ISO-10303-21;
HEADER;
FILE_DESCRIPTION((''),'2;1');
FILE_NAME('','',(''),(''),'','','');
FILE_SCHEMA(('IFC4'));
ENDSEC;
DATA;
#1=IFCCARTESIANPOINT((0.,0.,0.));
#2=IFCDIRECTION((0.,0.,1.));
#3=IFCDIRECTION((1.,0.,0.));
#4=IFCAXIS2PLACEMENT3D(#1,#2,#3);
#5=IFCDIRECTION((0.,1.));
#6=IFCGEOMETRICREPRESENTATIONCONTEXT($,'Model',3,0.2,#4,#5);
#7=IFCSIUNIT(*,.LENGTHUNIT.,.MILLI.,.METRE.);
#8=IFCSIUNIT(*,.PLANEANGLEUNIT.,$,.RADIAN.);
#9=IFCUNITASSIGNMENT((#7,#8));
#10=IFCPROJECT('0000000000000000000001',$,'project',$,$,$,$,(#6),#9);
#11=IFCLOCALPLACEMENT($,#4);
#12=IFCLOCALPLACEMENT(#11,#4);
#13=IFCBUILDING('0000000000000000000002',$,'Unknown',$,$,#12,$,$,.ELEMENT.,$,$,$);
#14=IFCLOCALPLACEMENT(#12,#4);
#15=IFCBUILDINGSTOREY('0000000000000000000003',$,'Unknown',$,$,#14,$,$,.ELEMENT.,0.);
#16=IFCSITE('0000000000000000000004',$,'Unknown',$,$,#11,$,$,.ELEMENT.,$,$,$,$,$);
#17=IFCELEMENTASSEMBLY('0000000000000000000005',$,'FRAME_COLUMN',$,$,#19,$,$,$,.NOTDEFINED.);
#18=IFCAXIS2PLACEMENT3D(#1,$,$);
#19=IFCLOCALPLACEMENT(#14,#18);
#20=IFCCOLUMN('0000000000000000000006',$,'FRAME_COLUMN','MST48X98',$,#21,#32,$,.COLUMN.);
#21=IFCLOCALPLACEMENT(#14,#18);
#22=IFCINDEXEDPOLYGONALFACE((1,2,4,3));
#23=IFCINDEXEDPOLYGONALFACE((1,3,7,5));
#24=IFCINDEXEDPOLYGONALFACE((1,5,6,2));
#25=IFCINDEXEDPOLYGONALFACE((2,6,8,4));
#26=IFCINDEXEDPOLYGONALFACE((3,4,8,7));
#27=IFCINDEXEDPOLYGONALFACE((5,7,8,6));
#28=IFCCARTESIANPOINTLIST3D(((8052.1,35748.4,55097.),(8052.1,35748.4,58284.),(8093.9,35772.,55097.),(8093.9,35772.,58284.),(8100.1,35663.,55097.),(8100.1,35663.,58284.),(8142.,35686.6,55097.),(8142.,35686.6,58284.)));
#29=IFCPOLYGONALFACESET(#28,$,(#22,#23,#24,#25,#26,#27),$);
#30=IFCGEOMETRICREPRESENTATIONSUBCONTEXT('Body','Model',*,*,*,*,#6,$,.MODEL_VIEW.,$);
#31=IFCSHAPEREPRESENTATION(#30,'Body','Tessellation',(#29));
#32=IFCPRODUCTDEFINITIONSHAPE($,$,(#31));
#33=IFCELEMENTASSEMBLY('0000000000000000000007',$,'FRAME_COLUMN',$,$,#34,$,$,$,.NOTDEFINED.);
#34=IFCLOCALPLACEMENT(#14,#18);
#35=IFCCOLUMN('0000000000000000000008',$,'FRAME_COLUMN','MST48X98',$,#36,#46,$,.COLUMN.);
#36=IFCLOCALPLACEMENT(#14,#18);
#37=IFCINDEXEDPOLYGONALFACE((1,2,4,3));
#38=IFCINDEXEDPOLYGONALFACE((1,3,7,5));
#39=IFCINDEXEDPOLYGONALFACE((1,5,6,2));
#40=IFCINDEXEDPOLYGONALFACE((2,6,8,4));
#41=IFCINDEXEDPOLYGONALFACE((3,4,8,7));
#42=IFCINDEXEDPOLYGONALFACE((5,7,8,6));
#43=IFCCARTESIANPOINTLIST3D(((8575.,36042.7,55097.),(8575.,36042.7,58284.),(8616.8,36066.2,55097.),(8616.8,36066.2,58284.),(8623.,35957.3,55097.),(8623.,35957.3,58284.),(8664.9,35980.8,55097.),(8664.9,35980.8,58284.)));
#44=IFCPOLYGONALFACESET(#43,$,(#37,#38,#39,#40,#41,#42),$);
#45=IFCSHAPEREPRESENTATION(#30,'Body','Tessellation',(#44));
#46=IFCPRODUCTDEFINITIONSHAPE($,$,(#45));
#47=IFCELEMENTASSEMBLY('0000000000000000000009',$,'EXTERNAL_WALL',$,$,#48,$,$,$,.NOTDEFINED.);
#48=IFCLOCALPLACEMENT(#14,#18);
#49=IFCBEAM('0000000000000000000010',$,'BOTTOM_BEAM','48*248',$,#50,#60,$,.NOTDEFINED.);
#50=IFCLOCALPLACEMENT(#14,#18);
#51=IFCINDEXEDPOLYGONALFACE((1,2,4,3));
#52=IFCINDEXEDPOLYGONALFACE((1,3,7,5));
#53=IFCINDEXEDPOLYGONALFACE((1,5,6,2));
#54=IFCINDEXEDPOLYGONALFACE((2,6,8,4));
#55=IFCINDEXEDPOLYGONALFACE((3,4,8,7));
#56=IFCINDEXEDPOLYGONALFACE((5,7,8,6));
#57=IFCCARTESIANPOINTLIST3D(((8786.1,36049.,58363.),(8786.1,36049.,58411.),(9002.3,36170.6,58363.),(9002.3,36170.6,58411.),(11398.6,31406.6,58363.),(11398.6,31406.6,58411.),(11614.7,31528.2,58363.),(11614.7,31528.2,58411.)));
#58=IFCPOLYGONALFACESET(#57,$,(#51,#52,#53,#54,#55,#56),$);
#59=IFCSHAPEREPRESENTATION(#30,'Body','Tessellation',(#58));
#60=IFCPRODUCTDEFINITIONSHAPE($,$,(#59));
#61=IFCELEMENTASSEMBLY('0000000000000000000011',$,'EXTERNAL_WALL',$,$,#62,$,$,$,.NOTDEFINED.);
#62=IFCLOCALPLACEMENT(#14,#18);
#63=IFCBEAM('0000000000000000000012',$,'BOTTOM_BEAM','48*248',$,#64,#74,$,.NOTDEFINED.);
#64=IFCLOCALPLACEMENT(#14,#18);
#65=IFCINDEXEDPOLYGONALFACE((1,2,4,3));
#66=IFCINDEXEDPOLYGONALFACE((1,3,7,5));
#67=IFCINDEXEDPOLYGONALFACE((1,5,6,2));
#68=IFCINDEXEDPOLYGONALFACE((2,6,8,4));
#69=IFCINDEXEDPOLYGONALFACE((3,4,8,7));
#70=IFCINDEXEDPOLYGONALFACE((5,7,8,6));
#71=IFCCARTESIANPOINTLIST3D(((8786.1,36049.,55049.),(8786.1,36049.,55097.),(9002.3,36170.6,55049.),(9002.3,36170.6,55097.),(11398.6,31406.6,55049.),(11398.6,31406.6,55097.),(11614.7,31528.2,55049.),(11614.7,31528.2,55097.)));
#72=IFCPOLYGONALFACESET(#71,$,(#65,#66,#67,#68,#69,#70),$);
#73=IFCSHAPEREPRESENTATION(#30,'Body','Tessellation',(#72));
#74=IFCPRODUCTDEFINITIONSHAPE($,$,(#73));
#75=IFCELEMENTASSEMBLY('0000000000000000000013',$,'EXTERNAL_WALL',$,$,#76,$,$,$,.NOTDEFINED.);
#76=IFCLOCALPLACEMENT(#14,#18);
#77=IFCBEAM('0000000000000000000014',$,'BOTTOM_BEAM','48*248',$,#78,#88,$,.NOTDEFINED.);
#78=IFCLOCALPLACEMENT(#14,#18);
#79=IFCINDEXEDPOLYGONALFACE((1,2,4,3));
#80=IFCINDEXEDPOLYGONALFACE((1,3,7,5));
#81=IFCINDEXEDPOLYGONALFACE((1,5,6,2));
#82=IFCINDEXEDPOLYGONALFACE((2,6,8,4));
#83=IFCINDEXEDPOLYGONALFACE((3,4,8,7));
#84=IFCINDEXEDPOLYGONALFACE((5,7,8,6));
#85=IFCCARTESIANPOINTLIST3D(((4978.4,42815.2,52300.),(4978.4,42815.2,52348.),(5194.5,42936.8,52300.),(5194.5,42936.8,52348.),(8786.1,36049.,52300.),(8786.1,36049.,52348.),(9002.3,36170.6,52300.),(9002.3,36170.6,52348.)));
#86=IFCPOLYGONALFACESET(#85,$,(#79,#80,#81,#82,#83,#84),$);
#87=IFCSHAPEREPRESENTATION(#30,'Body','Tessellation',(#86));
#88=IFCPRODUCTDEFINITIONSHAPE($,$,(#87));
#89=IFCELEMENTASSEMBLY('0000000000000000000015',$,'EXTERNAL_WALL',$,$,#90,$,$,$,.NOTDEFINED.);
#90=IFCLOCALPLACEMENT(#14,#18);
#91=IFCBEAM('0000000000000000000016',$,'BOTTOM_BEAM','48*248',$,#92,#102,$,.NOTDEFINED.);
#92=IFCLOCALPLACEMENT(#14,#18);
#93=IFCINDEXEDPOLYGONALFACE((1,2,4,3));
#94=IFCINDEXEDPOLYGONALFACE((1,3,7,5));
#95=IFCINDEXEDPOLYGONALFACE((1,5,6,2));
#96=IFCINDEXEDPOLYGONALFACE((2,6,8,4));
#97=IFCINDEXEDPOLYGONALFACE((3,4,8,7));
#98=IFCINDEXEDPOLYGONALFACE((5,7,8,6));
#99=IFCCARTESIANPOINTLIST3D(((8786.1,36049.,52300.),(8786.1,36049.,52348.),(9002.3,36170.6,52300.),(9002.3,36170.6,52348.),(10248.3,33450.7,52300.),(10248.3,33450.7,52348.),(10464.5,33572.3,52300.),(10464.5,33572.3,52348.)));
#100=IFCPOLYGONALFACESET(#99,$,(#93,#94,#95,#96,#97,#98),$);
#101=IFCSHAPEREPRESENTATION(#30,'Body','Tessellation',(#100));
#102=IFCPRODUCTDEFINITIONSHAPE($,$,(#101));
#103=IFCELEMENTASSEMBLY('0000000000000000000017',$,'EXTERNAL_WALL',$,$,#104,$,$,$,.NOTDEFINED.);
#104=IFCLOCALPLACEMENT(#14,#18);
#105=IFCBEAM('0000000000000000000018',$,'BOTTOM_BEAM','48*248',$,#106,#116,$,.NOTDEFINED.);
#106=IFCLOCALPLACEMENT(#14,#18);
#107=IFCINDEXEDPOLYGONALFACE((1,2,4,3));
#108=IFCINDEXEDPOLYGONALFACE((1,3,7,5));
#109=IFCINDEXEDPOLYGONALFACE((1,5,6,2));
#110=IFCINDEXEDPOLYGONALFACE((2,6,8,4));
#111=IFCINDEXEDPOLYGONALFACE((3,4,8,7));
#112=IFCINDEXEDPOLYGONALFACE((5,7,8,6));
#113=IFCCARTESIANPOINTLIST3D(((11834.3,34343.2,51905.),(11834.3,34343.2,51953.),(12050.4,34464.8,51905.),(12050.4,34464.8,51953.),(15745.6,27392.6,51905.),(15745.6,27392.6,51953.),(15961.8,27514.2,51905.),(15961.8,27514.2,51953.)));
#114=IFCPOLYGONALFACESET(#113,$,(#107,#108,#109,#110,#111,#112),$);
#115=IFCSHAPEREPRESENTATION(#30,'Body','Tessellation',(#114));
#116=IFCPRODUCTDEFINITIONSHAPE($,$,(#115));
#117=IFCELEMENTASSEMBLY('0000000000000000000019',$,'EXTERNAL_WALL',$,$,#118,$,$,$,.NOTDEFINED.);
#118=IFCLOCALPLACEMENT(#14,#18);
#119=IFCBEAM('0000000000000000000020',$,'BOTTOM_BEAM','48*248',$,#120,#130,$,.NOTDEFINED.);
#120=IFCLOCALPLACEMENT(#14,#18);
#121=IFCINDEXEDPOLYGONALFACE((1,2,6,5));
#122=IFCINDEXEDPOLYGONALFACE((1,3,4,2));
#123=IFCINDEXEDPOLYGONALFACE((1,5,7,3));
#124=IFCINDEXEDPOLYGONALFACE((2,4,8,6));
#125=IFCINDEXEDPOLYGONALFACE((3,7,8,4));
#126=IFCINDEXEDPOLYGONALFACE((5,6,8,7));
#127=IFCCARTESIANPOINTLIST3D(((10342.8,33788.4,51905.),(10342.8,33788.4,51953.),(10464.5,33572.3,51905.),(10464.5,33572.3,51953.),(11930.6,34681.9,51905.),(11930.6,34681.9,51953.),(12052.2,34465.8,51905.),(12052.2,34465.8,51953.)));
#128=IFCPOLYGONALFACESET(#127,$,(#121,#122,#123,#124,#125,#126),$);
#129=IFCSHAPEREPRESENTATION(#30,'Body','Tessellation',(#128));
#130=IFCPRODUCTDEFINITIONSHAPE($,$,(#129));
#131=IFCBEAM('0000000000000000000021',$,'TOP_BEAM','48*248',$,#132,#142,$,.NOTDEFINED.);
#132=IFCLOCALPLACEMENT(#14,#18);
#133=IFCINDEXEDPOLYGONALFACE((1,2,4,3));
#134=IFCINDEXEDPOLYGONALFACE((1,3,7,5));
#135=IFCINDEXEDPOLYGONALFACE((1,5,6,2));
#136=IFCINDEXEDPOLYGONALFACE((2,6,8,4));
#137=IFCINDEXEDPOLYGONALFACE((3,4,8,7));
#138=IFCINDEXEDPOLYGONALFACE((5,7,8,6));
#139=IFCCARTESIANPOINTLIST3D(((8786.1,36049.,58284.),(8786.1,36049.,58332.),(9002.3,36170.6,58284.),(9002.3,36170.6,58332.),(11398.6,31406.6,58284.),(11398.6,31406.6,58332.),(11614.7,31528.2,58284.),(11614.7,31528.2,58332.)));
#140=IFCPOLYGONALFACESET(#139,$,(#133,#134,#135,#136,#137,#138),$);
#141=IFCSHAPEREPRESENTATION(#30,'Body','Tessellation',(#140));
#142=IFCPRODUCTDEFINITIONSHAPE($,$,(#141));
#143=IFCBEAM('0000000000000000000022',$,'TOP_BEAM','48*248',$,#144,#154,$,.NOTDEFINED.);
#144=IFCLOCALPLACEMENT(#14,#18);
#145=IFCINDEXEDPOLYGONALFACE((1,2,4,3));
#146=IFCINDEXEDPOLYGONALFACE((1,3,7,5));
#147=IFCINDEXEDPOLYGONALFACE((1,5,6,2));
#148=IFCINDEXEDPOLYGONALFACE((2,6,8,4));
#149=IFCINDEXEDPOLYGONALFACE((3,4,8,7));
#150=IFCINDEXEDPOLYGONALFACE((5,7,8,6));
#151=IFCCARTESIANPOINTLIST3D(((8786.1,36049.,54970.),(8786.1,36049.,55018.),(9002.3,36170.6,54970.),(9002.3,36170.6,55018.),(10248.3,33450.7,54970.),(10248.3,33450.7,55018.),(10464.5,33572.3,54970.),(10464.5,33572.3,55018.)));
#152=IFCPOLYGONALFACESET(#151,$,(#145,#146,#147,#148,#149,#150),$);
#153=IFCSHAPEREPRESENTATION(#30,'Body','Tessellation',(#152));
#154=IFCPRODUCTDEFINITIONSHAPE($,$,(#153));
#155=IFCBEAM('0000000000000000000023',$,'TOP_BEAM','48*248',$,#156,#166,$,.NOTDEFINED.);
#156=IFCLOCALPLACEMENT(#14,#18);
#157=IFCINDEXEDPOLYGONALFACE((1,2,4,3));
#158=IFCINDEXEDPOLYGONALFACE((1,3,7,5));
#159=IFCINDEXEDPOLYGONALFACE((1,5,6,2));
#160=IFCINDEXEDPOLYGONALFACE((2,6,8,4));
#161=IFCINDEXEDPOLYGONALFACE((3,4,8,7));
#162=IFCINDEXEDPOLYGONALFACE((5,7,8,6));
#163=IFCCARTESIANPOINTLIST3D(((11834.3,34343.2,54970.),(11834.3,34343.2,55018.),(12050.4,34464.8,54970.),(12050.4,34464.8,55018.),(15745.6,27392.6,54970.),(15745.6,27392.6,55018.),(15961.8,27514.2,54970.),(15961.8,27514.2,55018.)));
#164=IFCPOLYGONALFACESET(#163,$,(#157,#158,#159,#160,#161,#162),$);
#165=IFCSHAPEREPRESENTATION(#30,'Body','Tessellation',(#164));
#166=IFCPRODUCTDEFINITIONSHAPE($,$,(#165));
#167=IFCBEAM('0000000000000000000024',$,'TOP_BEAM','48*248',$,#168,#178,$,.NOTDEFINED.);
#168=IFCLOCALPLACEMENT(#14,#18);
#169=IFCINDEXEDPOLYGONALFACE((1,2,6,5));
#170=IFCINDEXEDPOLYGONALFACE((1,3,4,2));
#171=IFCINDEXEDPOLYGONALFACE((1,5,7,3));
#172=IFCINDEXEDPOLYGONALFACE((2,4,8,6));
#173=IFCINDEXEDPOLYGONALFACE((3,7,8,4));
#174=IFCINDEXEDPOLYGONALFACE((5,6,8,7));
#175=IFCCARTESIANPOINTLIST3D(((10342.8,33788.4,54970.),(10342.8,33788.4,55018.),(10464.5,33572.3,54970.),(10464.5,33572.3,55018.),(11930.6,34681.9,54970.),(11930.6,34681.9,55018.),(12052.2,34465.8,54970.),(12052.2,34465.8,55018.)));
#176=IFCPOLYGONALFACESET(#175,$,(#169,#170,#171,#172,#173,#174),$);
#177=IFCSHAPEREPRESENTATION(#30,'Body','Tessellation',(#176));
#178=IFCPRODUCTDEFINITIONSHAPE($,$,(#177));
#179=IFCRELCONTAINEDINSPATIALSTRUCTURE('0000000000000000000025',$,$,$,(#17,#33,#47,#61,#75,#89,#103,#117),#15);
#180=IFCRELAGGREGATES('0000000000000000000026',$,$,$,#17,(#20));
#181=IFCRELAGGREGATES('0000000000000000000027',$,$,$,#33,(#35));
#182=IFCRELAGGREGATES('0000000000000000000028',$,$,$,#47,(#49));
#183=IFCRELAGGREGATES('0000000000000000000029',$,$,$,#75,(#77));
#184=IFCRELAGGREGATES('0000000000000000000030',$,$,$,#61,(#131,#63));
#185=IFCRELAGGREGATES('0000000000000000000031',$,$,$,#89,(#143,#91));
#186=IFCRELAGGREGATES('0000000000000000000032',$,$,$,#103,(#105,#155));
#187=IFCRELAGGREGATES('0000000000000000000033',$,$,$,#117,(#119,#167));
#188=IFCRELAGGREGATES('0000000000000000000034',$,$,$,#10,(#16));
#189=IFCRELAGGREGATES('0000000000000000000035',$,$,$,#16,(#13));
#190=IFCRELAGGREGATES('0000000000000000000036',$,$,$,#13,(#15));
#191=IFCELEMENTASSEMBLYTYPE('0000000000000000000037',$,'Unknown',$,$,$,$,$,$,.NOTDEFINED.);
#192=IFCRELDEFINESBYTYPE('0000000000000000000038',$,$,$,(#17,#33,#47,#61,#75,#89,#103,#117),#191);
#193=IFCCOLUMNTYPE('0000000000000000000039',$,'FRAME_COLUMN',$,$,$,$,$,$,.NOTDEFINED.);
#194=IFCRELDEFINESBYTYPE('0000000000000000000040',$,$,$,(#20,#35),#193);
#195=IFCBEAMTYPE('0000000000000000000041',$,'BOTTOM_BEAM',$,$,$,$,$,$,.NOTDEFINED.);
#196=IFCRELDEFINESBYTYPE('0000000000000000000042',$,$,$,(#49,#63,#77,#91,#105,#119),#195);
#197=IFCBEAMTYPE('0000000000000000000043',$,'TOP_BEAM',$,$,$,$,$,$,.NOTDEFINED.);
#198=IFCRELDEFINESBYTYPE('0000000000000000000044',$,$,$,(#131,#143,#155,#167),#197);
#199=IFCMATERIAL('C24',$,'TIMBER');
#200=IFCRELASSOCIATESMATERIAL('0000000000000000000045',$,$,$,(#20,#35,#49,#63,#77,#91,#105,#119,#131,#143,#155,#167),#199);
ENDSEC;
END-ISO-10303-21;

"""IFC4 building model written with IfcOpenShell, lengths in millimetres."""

from ifc_helpers import new_model, si_unit, direction, frame, origin_with_axes, origin_2d_with_axis, place, context, subcontext, project, spatial, polyline, rectangle, outline, extrude, material, material_profile, profile_set, profile_usage, type_object, element, aggregate, save


model = new_model("IFC4")

# Units and contexts
model_context = context("Model", 3, precision=0.2, world=origin_with_axes(), true_north=direction((0.0, 1.0)))
body_context = subcontext(model_context, "Body", "Model", "MODEL_VIEW")
ifc_project = project(units=[si_unit("LENGTHUNIT", "METRE", prefix="MILLI"), si_unit("PLANEANGLEUNIT", "RADIAN")], contexts=[model_context])

# Site, building, storey
site_placement = place(None, origin_with_axes())
site = spatial("IfcSite", under=ifc_project, at=site_placement, Name="Unknown", CompositionType="ELEMENT")
building_placement = place(site_placement, origin_with_axes())
building = spatial("IfcBuilding", under=site, at=building_placement, Name="Unknown", CompositionType="ELEMENT")
storey_placement = place(building_placement, origin_with_axes())
storey = spatial("IfcBuildingStorey", under=building, at=storey_placement, Name="Unknown", CompositionType="ELEMENT", Elevation=0.0)

# Element assemblies, columns
element_assembly_type = type_object("IfcElementAssemblyType", Name="Unknown", PredefinedType="NOTDEFINED")
ifc_material_1 = material(Name="C24", Category="TIMBER")
ifc_material_profile_1 = material_profile(ifc_material_1, outline(polyline([(-24.0, 49.0), (-24.0, -49.0), (24.0, -49.0), (24.0, 49.0), (-24.0, 49.0)])), Name="MST48X98")
ifc_profile_set_1 = profile_set([ifc_material_profile_1])
column_type = type_object("IfcColumnType", Name="FRAME_COLUMN")
ifc_profile_usage_1 = profile_usage(ifc_profile_set_1, cardinal=9)
assembly_1_placement = place(storey_placement, frame((8097.0, 35717.5, 55097.0), z_axis=(-0.871487, -0.490418, 0.0), x_axis=(0.0, 0.0, 1.0)))
assembly_1 = element("IfcElementAssembly", 1, at=assembly_1_placement, inside=storey, type_object=element_assembly_type, Name="FRAME_COLUMN", PredefinedType="NOTDEFINED")
column_1_placement = place(assembly_1_placement, origin_with_axes())
column_1 = element("IfcColumn", 2, at=column_1_placement, type_object=column_type, material=ifc_profile_usage_1, Name="FRAME_COLUMN", Description="MST48X98", PredefinedType="COLUMN", context=body_context, shape_type="SolidModel", body=[
    extrude(outline(polyline([(-24.0, 49.0), (-24.0, -49.0), (24.0, -49.0), (24.0, 49.0), (-24.0, 49.0)])), frame((0.0, 0.0, 0.0), z_axis=(-1.0, 0.0, 0.0), x_axis=(0.0, 0.0, 1.0)), (0.0, 0.0, -1.0), 3187.0),
])
aggregate(assembly_1, [column_1])
assembly_2_placement = place(storey_placement, frame((8619.9, 36011.8, 55097.0), z_axis=(-0.871487, -0.490418, 0.0), x_axis=(0.0, 0.0, 1.0)))
assembly_2 = element("IfcElementAssembly", 3, at=assembly_2_placement, inside=storey, type_object=element_assembly_type, Name="FRAME_COLUMN", PredefinedType="NOTDEFINED")
column_2_placement = place(assembly_2_placement, origin_with_axes())
column_2 = element("IfcColumn", 4, at=column_2_placement, type_object=column_type, material=ifc_profile_usage_1, Name="FRAME_COLUMN", Description="MST48X98", PredefinedType="COLUMN", context=body_context, shape_type="SolidModel", body=[
    extrude(outline(polyline([(-24.0, 49.0), (-24.0, -49.0), (24.0, -49.0), (24.0, 49.0), (-24.0, 49.0)])), frame((0.0, 0.0, 0.0), z_axis=(-1.0, 0.0, 0.0), x_axis=(0.0, 0.0, 1.0)), (0.0, 0.0, -1.0), 3187.0),
])
aggregate(assembly_2, [column_2])

# Element assemblies, beams
assembly_3_placement = place(storey_placement, frame((8894.2, 36109.8, 61622.0), z_axis=(-0.871487, -0.490418, 0.0), x_axis=(0.490421, -0.871485, 0.0)))
assembly_3 = element("IfcElementAssembly", 5, at=assembly_3_placement, inside=storey, type_object=element_assembly_type, Name="EXTERNAL_WALL", PredefinedType="NOTDEFINED")
ifc_material_profile_2 = material_profile(ifc_material_1, rectangle(XDim=248.0, YDim=48.0, at=origin_2d_with_axis()), Name="48*248")
ifc_profile_set_2 = profile_set([ifc_material_profile_2])
ifc_profile_usage_2 = profile_usage(ifc_profile_set_2, cardinal=3)
beam_type_1 = type_object("IfcBeamType", Name="BOTTOM_BEAM")
beam_1_placement = place(assembly_3_placement, frame((0.0, -3235.0, 0.0), z_axis=(0.0, 0.0, 1.0), x_axis=(1.0, 0.0, 0.0)))
beam_1 = element("IfcBeam", 6, at=beam_1_placement, type_object=beam_type_1, material=ifc_profile_usage_2, Name="BOTTOM_BEAM", Description="48*248", PredefinedType="NOTDEFINED", context=body_context, shape_type="SolidModel", body=[
    extrude(rectangle(XDim=248.0, YDim=48.0, at=origin_2d_with_axis()), frame((0.0, 0.0, 0.0), z_axis=(-1.0, 0.0, 0.0), x_axis=(0.0, 0.0, 1.0)), (0.0, 0.0, -1.0), 5327.0),
])
aggregate(assembly_3, [beam_1])
assembly_4_placement = place(storey_placement, frame((8894.2, 36109.8, 58308.0), z_axis=(-0.871487, -0.490418, 0.0), x_axis=(0.490421, -0.871485, 0.0)))
assembly_4 = element("IfcElementAssembly", 7, at=assembly_4_placement, inside=storey, type_object=element_assembly_type, Name="EXTERNAL_WALL", PredefinedType="NOTDEFINED")
beam_2_placement = place(assembly_4_placement, frame((0.0, -3235.0, 0.0), z_axis=(0.0, 0.0, 1.0), x_axis=(1.0, 0.0, 0.0)))
beam_2 = element("IfcBeam", 8, at=beam_2_placement, type_object=beam_type_1, material=ifc_profile_usage_2, Name="BOTTOM_BEAM", Description="48*248", PredefinedType="NOTDEFINED", context=body_context, shape_type="SolidModel", body=[
    extrude(rectangle(XDim=248.0, YDim=48.0, at=origin_2d_with_axis()), frame((0.0, 0.0, 0.0), z_axis=(-1.0, 0.0, 0.0), x_axis=(0.0, 0.0, 1.0)), (0.0, 0.0, -1.0), 5327.0),
])
assembly_5_placement = place(storey_placement, frame((5086.5, 42876.0, 54994.0), z_axis=(-0.871477, -0.490436, 0.0), x_axis=(0.490442, -0.871474, 0.0)))
assembly_5 = element("IfcElementAssembly", 9, at=assembly_5_placement, inside=storey, type_object=element_assembly_type, Name="EXTERNAL_WALL", PredefinedType="NOTDEFINED")
beam_3_placement = place(assembly_5_placement, frame((0.0, -2670.0, 0.0), z_axis=(0.0, 0.0, 1.0), x_axis=(1.0, 0.0, 0.0)))
beam_3 = element("IfcBeam", 10, at=beam_3_placement, type_object=beam_type_1, material=ifc_profile_usage_2, Name="BOTTOM_BEAM", Description="48*248", PredefinedType="NOTDEFINED", context=body_context, shape_type="SolidModel", body=[
    extrude(rectangle(XDim=248.0, YDim=48.0, at=origin_2d_with_axis()), frame((0.0, 0.0, 0.0), z_axis=(-1.0, 0.0, 0.0), x_axis=(0.0, 0.0, 1.0)), (0.0, 0.0, -1.0), 7764.0),
])
aggregate(assembly_5, [beam_3])
assembly_6_placement = place(storey_placement, frame((8894.2, 36109.8, 54994.0), z_axis=(-0.871487, -0.490418, 0.0), x_axis=(0.490421, -0.871485, 0.0)))
assembly_6 = element("IfcElementAssembly", 11, at=assembly_6_placement, inside=storey, type_object=element_assembly_type, Name="EXTERNAL_WALL", PredefinedType="NOTDEFINED")
beam_4_placement = place(assembly_6_placement, frame((0.0, -2670.0, 0.0), z_axis=(0.0, 0.0, 1.0), x_axis=(1.0, 0.0, 0.0)))
beam_4 = element("IfcBeam", 12, at=beam_4_placement, type_object=beam_type_1, material=ifc_profile_usage_2, Name="BOTTOM_BEAM", Description="48*248", PredefinedType="NOTDEFINED", context=body_context, shape_type="SolidModel", body=[
    extrude(rectangle(XDim=248.0, YDim=48.0, at=origin_2d_with_axis()), frame((0.0, 0.0, 0.0), z_axis=(-1.0, 0.0, 0.0), x_axis=(0.0, 0.0, 1.0)), (0.0, 0.0, -1.0), 2981.5),
])
assembly_7_placement = place(storey_placement, frame((11942.4, 34404.0, 54994.0), z_axis=(-0.871487, -0.490418, 0.0), x_axis=(0.490421, -0.871485, 0.0)))
assembly_7 = element("IfcElementAssembly", 13, at=assembly_7_placement, inside=storey, type_object=element_assembly_type, Name="EXTERNAL_WALL", PredefinedType="NOTDEFINED")
beam_5_placement = place(assembly_7_placement, frame((0.0, -3065.0, 0.0), z_axis=(0.0, 0.0, 1.0), x_axis=(1.0, 0.0, 0.0)))
beam_5 = element("IfcBeam", 14, at=beam_5_placement, type_object=beam_type_1, material=ifc_profile_usage_2, Name="BOTTOM_BEAM", Description="48*248", PredefinedType="NOTDEFINED", context=body_context, shape_type="SolidModel", body=[
    extrude(rectangle(XDim=248.0, YDim=48.0, at=origin_2d_with_axis()), frame((0.0, 0.0, 0.0), z_axis=(-1.0, 0.0, 0.0), x_axis=(0.0, 0.0, 1.0)), (0.0, 0.0, -1.0), 7975.5),
])
assembly_8_placement = place(storey_placement, frame((10403.7, 33680.4, 54994.0), z_axis=(0.490421, -0.871485, 0.0), x_axis=(0.871484, 0.490423, 0.0)))
assembly_8 = element("IfcElementAssembly", 15, at=assembly_8_placement, inside=storey, type_object=element_assembly_type, Name="EXTERNAL_WALL", PredefinedType="NOTDEFINED")
beam_6_placement = place(assembly_8_placement, frame((0.0, -3065.0, 0.0), z_axis=(0.0, 0.0, 1.0), x_axis=(1.0, 0.0, 0.0)))
beam_6 = element("IfcBeam", 16, at=beam_6_placement, type_object=beam_type_1, material=ifc_profile_usage_2, Name="BOTTOM_BEAM", Description="48*248", PredefinedType="NOTDEFINED", context=body_context, shape_type="SolidModel", body=[
    extrude(rectangle(XDim=248.0, YDim=48.0, at=origin_2d_with_axis()), frame((0.0, 0.0, 0.0), z_axis=(-1.0, 0.0, 0.0), x_axis=(0.0, 0.0, 1.0)), (0.0, 0.0, -1.0), 1821.9),
])

# Beams
beam_type_2 = type_object("IfcBeamType", Name="TOP_BEAM")
beam_7_placement = place(assembly_4_placement, origin_with_axes())
beam_7 = element("IfcBeam", 17, at=beam_7_placement, type_object=beam_type_2, material=ifc_profile_usage_2, Name="TOP_BEAM", Description="48*248", PredefinedType="NOTDEFINED", context=body_context, shape_type="SolidModel", body=[
    extrude(rectangle(XDim=248.0, YDim=48.0, at=origin_2d_with_axis()), frame((0.0, 0.0, 0.0), z_axis=(-1.0, 0.0, 0.0), x_axis=(0.0, 0.0, 1.0)), (0.0, 0.0, -1.0), 5327.0),
])
aggregate(assembly_4, [beam_7, beam_2])
beam_8_placement = place(assembly_6_placement, origin_with_axes())
beam_8 = element("IfcBeam", 18, at=beam_8_placement, type_object=beam_type_2, material=ifc_profile_usage_2, Name="TOP_BEAM", Description="48*248", PredefinedType="NOTDEFINED", context=body_context, shape_type="SolidModel", body=[
    extrude(rectangle(XDim=248.0, YDim=48.0, at=origin_2d_with_axis()), frame((0.0, 0.0, 0.0), z_axis=(-1.0, 0.0, 0.0), x_axis=(0.0, 0.0, 1.0)), (0.0, 0.0, -1.0), 2981.5),
])
aggregate(assembly_6, [beam_8, beam_4])
beam_9_placement = place(assembly_7_placement, origin_with_axes())
beam_9 = element("IfcBeam", 19, at=beam_9_placement, type_object=beam_type_2, material=ifc_profile_usage_2, Name="TOP_BEAM", Description="48*248", PredefinedType="NOTDEFINED", context=body_context, shape_type="SolidModel", body=[
    extrude(rectangle(XDim=248.0, YDim=48.0, at=origin_2d_with_axis()), frame((0.0, 0.0, 0.0), z_axis=(-1.0, 0.0, 0.0), x_axis=(0.0, 0.0, 1.0)), (0.0, 0.0, -1.0), 7975.5),
])
aggregate(assembly_7, [beam_5, beam_9])
beam_10_placement = place(assembly_8_placement, origin_with_axes())
beam_10 = element("IfcBeam", 20, at=beam_10_placement, type_object=beam_type_2, material=ifc_profile_usage_2, Name="TOP_BEAM", Description="48*248", PredefinedType="NOTDEFINED", context=body_context, shape_type="SolidModel", body=[
    extrude(rectangle(XDim=248.0, YDim=48.0, at=origin_2d_with_axis()), frame((0.0, 0.0, 0.0), z_axis=(-1.0, 0.0, 0.0), x_axis=(0.0, 0.0, 1.0)), (0.0, 0.0, -1.0), 1821.9),
])
aggregate(assembly_8, [beam_6, beam_10])

save(model, "model.ifc")
